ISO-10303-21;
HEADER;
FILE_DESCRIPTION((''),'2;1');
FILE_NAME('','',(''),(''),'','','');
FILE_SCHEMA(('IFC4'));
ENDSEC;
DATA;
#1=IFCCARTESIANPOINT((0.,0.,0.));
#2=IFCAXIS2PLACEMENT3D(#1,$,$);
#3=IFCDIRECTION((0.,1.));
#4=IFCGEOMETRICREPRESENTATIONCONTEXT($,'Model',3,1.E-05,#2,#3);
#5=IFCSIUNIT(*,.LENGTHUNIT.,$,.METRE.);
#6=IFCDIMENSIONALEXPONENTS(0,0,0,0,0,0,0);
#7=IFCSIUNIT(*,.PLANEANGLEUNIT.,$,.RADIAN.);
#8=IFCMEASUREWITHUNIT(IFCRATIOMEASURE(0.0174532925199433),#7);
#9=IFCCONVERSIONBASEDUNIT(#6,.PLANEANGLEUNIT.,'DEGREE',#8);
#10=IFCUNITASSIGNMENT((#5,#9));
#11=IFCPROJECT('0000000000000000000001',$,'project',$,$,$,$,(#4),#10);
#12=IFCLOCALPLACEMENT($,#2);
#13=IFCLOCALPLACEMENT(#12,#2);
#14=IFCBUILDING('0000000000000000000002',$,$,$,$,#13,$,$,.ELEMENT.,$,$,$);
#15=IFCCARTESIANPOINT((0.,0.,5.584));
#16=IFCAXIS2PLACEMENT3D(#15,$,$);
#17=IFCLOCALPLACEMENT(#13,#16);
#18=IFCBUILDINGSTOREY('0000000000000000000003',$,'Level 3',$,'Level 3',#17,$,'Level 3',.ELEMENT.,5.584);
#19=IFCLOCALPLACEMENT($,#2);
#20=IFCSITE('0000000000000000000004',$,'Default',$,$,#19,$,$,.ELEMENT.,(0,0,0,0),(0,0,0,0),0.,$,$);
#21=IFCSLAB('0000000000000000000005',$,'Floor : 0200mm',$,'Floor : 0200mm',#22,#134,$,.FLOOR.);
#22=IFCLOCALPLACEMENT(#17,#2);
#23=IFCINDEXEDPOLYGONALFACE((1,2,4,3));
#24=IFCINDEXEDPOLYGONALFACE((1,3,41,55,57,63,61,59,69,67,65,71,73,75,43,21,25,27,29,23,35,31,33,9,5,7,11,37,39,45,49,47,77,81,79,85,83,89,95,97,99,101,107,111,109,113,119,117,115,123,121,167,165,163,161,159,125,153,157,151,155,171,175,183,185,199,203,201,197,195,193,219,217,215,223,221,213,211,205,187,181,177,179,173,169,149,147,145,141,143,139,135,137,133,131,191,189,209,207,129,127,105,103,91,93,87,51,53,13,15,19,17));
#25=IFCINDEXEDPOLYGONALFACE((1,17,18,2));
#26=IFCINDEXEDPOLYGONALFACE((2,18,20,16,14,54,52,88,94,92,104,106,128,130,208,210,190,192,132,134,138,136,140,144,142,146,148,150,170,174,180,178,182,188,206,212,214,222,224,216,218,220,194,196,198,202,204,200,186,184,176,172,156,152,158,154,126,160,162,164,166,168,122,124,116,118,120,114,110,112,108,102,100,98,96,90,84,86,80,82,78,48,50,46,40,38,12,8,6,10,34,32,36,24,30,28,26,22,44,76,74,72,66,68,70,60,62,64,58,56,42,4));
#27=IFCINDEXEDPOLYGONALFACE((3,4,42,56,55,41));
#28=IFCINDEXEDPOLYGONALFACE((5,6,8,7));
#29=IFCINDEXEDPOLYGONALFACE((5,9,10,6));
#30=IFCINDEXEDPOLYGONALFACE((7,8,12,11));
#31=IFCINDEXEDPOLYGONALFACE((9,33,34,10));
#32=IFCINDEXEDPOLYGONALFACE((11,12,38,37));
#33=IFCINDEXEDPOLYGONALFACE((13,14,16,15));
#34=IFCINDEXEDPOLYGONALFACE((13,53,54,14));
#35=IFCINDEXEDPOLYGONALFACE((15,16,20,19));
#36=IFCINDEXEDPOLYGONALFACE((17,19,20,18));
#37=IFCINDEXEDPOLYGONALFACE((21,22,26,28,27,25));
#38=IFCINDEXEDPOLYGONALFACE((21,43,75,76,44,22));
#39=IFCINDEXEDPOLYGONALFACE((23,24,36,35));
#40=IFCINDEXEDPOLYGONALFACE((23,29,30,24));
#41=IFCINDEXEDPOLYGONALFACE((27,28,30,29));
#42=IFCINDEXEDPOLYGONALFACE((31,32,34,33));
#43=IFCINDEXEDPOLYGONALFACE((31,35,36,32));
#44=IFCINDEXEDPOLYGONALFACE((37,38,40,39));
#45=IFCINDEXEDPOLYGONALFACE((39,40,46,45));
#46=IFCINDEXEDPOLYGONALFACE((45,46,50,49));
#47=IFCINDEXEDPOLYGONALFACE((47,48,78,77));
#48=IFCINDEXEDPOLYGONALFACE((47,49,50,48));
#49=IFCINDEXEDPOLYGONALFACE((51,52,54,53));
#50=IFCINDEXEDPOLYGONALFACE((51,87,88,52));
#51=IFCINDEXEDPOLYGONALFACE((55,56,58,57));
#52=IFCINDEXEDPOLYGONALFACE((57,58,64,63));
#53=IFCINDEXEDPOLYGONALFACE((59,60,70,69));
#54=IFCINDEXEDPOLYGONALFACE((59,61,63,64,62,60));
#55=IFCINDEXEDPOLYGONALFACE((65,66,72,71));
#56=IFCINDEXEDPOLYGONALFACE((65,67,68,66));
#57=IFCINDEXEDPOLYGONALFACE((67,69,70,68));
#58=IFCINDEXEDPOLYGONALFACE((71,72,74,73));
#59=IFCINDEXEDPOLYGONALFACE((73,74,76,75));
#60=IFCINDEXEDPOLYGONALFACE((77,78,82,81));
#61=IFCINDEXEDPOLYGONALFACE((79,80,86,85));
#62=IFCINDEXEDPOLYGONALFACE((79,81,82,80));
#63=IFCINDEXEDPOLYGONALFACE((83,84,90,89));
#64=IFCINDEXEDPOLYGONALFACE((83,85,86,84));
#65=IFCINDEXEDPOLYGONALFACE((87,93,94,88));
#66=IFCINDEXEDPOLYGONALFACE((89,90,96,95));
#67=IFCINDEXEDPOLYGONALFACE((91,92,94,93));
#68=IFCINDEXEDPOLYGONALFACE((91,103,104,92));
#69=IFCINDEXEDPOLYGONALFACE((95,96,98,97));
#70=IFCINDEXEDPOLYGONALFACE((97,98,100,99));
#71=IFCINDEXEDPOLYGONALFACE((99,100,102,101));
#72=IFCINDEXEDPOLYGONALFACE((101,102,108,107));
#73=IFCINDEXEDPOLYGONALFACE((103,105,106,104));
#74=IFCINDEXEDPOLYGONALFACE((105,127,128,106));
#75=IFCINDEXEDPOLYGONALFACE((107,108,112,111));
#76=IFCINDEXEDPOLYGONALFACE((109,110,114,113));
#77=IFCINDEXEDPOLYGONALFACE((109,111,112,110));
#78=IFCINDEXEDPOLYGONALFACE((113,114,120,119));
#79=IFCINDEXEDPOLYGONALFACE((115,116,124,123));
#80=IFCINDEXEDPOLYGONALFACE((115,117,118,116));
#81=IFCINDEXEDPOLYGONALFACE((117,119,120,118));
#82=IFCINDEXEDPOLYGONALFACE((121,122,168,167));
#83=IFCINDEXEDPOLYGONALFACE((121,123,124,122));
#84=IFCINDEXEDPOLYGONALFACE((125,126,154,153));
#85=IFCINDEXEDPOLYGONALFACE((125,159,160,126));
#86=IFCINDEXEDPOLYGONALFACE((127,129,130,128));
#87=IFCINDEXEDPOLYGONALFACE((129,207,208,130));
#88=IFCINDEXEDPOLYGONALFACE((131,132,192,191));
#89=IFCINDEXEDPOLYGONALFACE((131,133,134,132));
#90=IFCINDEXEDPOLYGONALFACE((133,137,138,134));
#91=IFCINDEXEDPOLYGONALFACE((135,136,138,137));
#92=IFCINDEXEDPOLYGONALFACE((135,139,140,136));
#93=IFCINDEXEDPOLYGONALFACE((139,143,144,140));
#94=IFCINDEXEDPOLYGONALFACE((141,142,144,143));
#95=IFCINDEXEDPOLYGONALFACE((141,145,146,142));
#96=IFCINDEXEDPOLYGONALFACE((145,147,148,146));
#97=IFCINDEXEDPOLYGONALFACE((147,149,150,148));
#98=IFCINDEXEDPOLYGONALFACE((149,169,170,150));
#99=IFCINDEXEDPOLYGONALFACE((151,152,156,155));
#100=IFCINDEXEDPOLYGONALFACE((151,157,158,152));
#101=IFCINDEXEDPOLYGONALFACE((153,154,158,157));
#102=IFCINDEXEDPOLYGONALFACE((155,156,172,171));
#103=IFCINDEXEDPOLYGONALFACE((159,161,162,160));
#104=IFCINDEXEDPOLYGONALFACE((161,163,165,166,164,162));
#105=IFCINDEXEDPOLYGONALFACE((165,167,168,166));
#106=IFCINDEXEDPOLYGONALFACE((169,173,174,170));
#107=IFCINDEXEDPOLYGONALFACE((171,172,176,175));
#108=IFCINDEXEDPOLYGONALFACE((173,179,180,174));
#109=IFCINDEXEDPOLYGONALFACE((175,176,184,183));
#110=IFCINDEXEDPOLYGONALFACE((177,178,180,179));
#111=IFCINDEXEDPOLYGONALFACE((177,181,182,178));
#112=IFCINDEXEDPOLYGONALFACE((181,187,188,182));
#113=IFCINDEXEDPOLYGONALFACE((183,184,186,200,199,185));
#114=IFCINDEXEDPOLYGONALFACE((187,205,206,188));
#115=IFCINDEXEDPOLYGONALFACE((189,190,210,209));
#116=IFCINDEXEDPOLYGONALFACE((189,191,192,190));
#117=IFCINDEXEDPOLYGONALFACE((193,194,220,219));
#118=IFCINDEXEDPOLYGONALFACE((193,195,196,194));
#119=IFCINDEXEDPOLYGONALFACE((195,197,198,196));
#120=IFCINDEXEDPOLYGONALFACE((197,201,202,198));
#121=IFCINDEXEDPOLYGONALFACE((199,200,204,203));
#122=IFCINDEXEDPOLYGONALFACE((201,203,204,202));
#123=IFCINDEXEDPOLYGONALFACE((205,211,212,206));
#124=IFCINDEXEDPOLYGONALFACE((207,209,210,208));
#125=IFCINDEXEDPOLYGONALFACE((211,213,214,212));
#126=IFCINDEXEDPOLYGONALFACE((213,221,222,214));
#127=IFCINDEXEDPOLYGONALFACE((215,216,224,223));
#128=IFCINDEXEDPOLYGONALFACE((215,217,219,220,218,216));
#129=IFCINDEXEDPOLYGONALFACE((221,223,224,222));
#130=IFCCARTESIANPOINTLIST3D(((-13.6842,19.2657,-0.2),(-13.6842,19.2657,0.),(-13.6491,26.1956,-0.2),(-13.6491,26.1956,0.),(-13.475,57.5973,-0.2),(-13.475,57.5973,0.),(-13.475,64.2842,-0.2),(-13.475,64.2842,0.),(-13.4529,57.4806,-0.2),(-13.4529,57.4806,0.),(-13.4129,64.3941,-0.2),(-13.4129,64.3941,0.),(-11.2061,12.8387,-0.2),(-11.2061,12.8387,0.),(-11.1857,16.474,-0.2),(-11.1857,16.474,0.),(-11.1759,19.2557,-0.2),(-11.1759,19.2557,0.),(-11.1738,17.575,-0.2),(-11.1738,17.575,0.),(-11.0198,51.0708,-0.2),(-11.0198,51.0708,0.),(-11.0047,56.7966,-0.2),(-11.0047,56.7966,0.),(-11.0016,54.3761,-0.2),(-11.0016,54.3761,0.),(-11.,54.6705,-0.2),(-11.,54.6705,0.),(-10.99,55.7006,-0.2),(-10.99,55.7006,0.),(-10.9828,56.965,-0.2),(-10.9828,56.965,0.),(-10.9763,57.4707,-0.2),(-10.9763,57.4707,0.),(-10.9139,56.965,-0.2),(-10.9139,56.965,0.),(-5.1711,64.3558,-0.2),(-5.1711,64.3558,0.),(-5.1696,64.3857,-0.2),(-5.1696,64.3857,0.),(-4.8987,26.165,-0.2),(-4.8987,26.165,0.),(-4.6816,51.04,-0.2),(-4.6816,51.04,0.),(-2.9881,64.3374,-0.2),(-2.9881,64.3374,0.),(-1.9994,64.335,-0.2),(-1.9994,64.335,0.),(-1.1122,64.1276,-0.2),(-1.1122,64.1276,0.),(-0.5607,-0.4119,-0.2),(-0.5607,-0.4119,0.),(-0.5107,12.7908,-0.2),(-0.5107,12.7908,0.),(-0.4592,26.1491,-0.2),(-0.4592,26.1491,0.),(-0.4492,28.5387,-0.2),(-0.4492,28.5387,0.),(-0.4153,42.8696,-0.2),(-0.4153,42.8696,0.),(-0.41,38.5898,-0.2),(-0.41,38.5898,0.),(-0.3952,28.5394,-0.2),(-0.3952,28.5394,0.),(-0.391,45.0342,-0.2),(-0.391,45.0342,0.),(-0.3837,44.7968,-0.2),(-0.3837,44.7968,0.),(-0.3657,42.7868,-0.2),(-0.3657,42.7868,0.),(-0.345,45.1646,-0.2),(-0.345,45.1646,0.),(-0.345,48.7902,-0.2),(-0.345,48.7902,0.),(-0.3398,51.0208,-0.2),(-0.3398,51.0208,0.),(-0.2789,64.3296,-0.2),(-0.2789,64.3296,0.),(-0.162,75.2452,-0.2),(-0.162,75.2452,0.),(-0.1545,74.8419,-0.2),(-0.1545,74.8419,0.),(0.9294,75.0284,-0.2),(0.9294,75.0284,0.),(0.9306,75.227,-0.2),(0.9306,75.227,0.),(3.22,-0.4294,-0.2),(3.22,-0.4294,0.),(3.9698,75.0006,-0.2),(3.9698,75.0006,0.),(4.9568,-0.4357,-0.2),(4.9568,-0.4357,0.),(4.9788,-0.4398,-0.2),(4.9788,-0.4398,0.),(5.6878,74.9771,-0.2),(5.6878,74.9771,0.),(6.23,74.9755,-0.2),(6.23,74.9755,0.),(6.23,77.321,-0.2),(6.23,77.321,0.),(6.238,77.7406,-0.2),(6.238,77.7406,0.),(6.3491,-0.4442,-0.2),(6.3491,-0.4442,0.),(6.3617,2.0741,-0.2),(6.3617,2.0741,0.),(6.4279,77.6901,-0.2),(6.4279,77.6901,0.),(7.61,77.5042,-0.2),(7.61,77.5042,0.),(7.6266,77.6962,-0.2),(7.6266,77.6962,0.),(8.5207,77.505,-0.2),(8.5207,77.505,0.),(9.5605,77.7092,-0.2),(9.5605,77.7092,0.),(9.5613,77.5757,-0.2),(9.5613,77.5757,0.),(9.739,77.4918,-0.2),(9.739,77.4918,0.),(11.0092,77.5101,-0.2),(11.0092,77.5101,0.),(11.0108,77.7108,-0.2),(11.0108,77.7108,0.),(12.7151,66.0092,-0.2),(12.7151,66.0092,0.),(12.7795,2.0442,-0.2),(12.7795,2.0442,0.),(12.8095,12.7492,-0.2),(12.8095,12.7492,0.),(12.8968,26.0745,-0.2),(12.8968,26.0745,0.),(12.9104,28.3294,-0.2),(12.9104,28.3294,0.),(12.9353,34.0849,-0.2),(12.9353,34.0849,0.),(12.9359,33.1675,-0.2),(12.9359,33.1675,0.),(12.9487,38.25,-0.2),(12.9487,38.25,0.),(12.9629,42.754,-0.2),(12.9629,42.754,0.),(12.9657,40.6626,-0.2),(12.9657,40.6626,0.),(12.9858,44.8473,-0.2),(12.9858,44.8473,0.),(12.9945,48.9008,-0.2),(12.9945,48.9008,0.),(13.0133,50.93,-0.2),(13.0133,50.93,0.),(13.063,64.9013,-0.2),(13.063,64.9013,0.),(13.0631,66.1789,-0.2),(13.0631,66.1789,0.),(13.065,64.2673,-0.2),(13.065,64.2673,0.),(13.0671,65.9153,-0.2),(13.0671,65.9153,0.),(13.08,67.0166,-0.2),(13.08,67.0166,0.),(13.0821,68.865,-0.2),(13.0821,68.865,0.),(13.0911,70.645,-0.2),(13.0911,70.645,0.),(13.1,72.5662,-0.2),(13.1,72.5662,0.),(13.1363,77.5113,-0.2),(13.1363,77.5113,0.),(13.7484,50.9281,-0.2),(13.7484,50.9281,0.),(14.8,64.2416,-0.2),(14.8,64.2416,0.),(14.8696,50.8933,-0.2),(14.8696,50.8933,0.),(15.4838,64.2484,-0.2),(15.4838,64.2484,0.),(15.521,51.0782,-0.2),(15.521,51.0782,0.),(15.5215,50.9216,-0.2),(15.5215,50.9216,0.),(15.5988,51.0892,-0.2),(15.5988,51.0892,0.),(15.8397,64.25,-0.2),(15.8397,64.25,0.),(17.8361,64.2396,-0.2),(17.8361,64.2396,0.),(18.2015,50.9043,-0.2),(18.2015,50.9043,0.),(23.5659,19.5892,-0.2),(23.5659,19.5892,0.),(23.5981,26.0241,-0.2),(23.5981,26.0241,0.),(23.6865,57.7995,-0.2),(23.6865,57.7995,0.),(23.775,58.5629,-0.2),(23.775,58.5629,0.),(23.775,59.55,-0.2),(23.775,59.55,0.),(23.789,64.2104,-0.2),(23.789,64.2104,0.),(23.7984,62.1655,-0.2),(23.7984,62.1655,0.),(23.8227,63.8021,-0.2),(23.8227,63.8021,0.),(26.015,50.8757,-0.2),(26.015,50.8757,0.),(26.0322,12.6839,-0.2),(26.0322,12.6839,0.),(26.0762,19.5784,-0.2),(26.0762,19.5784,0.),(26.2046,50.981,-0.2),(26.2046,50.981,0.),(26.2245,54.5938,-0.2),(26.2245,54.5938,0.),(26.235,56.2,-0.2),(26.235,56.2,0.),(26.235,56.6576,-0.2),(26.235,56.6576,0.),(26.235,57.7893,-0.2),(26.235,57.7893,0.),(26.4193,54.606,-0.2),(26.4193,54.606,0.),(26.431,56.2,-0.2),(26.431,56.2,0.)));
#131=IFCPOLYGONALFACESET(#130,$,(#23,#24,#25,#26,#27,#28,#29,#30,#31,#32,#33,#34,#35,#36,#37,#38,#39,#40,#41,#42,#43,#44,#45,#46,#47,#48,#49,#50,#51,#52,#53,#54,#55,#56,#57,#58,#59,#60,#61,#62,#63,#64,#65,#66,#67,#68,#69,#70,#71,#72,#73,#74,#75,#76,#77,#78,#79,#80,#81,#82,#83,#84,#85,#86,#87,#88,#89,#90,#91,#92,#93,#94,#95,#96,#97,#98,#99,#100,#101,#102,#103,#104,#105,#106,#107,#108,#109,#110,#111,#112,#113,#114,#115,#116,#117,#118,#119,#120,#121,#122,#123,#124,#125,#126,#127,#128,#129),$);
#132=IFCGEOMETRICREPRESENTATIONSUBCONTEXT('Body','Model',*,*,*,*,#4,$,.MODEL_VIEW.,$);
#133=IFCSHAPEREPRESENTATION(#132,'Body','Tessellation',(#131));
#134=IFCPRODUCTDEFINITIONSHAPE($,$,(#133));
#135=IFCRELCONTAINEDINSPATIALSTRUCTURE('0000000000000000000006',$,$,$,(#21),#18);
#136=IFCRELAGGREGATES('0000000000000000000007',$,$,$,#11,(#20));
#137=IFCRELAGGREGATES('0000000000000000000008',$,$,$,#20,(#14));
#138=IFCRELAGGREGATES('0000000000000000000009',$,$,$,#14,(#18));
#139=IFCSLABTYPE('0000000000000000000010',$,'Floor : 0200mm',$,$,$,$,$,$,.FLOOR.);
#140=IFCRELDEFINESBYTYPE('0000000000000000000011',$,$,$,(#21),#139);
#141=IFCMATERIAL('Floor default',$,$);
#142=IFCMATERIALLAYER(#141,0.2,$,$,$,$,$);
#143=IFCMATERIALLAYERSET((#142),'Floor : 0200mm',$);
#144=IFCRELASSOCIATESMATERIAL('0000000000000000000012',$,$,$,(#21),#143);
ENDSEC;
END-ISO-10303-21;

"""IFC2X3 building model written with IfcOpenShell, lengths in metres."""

from ifc_helpers import new_model, entity, si_unit, converted_unit, direction, frame, origin, place, context, subcontext, project, spatial, polyline, outline, extrude, material, layer, layer_set, layer_usage, type_object, element, save


model = new_model("IFC2X3")

# Units and contexts
model_context = context("Model", 3, precision=1e-05, world=origin(), true_north=direction((0.0, 1.0)))
body_context = subcontext(model_context, "Body", "Model", "MODEL_VIEW")
ifc_project = project(units=[si_unit("LENGTHUNIT", "METRE"), converted_unit("PLANEANGLEUNIT", "DEGREE", entity("IfcRatioMeasure", 0.0174532925199433), si_unit("PLANEANGLEUNIT", "RADIAN"), dimensions=[0, 0, 0, 0, 0, 0, 0])], contexts=[model_context])

# Site, building, storey
site_placement = place(None, origin())
site = spatial("IfcSite", under=ifc_project, at=site_placement, Name="Default", CompositionType="ELEMENT", RefLatitude=(0, 0, 0, 0), RefLongitude=(0, 0, 0, 0), RefElevation=0.0)
placement_1 = place(None, origin())
building_placement = place(placement_1, origin())
building = spatial("IfcBuilding", under=site, at=building_placement, CompositionType="ELEMENT")
storey_placement = place(building_placement, frame((0.0, 0.0, 5.584)))
storey = spatial("IfcBuildingStorey", under=building, at=storey_placement, Name="Level 3", ObjectType="Level 3", LongName="Level 3", CompositionType="ELEMENT", Elevation=5.584)

# Slab
ifc_material_1 = material(Name="Floor default")
ifc_layer_1 = layer(ifc_material_1, 0.2)
ifc_layer_set_1 = layer_set([ifc_layer_1], Name="Floor : 0200mm")
ifc_layer_usage_1 = layer_usage(ifc_layer_set_1, "AXIS3", "POSITIVE", 0.0)
slab_type = type_object("IfcSlabType", Name="Floor : 0200mm", PredefinedType="FLOOR")
slab_placement = place(storey_placement, origin())
element("IfcSlab", 1, at=slab_placement, inside=storey, type_object=slab_type, material=ifc_layer_usage_1, Name="Floor : 0200mm", ObjectType="Floor : 0200mm", PredefinedType="FLOOR", context=body_context, shape_type="SweptSolid", body=[
    extrude(outline(polyline([(13.063, 64.9013), (13.0671, 65.9153), (13.0631, 66.1789), (12.7151, 66.0092), (13.08, 67.0166), (13.0821, 68.865), (13.0911, 70.645), (13.1, 72.5662), (13.1363, 77.5113), (11.0092, 77.5101), (11.0108, 77.7108), (9.5605, 77.7092), (9.5613, 77.5757), (9.739, 77.4918), (8.5207, 77.505), (7.61, 77.5042), (7.6266, 77.6962), (6.4279, 77.6901), (6.238, 77.7406), (6.23, 77.321), (6.23, 74.9755), (5.6878, 74.9771), (3.9698, 75.0006), (0.9294, 75.0284), (0.9306, 75.227), (-0.162, 75.2452), (-0.1545, 74.8419), (-0.2789, 64.3296), (-1.9994, 64.335), (-1.1122, 64.1276), (-2.9881, 64.3374), (-5.1696, 64.3857), (-5.1711, 64.3558), (-13.4129, 64.3941), (-13.475, 64.2842), (-13.475, 57.5973), (-13.4529, 57.4806), (-10.9763, 57.4707), (-10.9828, 56.965), (-10.9139, 56.965), (-11.0047, 56.7966), (-10.99, 55.7006), (-11.0, 54.6705), (-11.0016, 54.3761), (-11.0198, 51.0708), (-4.6816, 51.04), (-0.3398, 51.0208), (-0.345, 48.7902), (-0.345, 45.1646), (-0.391, 45.0342), (-0.3837, 44.7968), (-0.3657, 42.7868), (-0.4153, 42.8696), (-0.41, 38.5898), (-0.3952, 28.5394), (-0.4492, 28.5387), (-0.4592, 26.1491), (-4.8987, 26.165), (-13.6491, 26.1956), (-13.6842, 19.2657), (-11.1759, 19.2557), (-11.1738, 17.575), (-11.1857, 16.474), (-11.2061, 12.8387), (-0.5107, 12.7908), (-0.5607, -0.4119), (3.22, -0.4294), (4.9788, -0.4398), (4.9568, -0.4357), (6.3491, -0.4442), (6.3617, 2.0741), (12.7795, 2.0442), (12.8095, 12.7492), (26.0322, 12.6839), (26.0762, 19.5784), (23.5659, 19.5892), (23.5981, 26.0241), (12.8968, 26.0745), (12.9104, 28.3294), (12.9359, 33.1675), (12.9353, 34.0849), (12.9487, 38.25), (12.9657, 40.6626), (12.9629, 42.754), (12.9858, 44.8473), (12.9945, 48.9008), (13.0133, 50.93), (13.7484, 50.9281), (14.8696, 50.8933), (15.5215, 50.9216), (15.521, 51.0782), (15.5988, 51.0892), (18.2015, 50.9043), (26.015, 50.8757), (26.2046, 50.981), (26.2245, 54.5938), (26.4193, 54.606), (26.431, 56.2), (26.235, 56.2), (26.235, 56.6576), (26.235, 57.7893), (23.6865, 57.7995), (23.775, 58.5629), (23.775, 59.55), (23.7984, 62.1655), (23.8227, 63.8021), (23.789, 64.2104), (17.8361, 64.2396), (15.8397, 64.25), (15.4838, 64.2484), (14.8, 64.2416), (13.065, 64.2673), (13.063, 64.9013)])), frame((0.0, 0.0, -0.2), z_axis=(0.0, 0.0, 1.0), x_axis=(1.0, 0.0, 0.0)), (0.0, 0.0, 1.0), 0.2),
])

save(model, "model.ifc")
